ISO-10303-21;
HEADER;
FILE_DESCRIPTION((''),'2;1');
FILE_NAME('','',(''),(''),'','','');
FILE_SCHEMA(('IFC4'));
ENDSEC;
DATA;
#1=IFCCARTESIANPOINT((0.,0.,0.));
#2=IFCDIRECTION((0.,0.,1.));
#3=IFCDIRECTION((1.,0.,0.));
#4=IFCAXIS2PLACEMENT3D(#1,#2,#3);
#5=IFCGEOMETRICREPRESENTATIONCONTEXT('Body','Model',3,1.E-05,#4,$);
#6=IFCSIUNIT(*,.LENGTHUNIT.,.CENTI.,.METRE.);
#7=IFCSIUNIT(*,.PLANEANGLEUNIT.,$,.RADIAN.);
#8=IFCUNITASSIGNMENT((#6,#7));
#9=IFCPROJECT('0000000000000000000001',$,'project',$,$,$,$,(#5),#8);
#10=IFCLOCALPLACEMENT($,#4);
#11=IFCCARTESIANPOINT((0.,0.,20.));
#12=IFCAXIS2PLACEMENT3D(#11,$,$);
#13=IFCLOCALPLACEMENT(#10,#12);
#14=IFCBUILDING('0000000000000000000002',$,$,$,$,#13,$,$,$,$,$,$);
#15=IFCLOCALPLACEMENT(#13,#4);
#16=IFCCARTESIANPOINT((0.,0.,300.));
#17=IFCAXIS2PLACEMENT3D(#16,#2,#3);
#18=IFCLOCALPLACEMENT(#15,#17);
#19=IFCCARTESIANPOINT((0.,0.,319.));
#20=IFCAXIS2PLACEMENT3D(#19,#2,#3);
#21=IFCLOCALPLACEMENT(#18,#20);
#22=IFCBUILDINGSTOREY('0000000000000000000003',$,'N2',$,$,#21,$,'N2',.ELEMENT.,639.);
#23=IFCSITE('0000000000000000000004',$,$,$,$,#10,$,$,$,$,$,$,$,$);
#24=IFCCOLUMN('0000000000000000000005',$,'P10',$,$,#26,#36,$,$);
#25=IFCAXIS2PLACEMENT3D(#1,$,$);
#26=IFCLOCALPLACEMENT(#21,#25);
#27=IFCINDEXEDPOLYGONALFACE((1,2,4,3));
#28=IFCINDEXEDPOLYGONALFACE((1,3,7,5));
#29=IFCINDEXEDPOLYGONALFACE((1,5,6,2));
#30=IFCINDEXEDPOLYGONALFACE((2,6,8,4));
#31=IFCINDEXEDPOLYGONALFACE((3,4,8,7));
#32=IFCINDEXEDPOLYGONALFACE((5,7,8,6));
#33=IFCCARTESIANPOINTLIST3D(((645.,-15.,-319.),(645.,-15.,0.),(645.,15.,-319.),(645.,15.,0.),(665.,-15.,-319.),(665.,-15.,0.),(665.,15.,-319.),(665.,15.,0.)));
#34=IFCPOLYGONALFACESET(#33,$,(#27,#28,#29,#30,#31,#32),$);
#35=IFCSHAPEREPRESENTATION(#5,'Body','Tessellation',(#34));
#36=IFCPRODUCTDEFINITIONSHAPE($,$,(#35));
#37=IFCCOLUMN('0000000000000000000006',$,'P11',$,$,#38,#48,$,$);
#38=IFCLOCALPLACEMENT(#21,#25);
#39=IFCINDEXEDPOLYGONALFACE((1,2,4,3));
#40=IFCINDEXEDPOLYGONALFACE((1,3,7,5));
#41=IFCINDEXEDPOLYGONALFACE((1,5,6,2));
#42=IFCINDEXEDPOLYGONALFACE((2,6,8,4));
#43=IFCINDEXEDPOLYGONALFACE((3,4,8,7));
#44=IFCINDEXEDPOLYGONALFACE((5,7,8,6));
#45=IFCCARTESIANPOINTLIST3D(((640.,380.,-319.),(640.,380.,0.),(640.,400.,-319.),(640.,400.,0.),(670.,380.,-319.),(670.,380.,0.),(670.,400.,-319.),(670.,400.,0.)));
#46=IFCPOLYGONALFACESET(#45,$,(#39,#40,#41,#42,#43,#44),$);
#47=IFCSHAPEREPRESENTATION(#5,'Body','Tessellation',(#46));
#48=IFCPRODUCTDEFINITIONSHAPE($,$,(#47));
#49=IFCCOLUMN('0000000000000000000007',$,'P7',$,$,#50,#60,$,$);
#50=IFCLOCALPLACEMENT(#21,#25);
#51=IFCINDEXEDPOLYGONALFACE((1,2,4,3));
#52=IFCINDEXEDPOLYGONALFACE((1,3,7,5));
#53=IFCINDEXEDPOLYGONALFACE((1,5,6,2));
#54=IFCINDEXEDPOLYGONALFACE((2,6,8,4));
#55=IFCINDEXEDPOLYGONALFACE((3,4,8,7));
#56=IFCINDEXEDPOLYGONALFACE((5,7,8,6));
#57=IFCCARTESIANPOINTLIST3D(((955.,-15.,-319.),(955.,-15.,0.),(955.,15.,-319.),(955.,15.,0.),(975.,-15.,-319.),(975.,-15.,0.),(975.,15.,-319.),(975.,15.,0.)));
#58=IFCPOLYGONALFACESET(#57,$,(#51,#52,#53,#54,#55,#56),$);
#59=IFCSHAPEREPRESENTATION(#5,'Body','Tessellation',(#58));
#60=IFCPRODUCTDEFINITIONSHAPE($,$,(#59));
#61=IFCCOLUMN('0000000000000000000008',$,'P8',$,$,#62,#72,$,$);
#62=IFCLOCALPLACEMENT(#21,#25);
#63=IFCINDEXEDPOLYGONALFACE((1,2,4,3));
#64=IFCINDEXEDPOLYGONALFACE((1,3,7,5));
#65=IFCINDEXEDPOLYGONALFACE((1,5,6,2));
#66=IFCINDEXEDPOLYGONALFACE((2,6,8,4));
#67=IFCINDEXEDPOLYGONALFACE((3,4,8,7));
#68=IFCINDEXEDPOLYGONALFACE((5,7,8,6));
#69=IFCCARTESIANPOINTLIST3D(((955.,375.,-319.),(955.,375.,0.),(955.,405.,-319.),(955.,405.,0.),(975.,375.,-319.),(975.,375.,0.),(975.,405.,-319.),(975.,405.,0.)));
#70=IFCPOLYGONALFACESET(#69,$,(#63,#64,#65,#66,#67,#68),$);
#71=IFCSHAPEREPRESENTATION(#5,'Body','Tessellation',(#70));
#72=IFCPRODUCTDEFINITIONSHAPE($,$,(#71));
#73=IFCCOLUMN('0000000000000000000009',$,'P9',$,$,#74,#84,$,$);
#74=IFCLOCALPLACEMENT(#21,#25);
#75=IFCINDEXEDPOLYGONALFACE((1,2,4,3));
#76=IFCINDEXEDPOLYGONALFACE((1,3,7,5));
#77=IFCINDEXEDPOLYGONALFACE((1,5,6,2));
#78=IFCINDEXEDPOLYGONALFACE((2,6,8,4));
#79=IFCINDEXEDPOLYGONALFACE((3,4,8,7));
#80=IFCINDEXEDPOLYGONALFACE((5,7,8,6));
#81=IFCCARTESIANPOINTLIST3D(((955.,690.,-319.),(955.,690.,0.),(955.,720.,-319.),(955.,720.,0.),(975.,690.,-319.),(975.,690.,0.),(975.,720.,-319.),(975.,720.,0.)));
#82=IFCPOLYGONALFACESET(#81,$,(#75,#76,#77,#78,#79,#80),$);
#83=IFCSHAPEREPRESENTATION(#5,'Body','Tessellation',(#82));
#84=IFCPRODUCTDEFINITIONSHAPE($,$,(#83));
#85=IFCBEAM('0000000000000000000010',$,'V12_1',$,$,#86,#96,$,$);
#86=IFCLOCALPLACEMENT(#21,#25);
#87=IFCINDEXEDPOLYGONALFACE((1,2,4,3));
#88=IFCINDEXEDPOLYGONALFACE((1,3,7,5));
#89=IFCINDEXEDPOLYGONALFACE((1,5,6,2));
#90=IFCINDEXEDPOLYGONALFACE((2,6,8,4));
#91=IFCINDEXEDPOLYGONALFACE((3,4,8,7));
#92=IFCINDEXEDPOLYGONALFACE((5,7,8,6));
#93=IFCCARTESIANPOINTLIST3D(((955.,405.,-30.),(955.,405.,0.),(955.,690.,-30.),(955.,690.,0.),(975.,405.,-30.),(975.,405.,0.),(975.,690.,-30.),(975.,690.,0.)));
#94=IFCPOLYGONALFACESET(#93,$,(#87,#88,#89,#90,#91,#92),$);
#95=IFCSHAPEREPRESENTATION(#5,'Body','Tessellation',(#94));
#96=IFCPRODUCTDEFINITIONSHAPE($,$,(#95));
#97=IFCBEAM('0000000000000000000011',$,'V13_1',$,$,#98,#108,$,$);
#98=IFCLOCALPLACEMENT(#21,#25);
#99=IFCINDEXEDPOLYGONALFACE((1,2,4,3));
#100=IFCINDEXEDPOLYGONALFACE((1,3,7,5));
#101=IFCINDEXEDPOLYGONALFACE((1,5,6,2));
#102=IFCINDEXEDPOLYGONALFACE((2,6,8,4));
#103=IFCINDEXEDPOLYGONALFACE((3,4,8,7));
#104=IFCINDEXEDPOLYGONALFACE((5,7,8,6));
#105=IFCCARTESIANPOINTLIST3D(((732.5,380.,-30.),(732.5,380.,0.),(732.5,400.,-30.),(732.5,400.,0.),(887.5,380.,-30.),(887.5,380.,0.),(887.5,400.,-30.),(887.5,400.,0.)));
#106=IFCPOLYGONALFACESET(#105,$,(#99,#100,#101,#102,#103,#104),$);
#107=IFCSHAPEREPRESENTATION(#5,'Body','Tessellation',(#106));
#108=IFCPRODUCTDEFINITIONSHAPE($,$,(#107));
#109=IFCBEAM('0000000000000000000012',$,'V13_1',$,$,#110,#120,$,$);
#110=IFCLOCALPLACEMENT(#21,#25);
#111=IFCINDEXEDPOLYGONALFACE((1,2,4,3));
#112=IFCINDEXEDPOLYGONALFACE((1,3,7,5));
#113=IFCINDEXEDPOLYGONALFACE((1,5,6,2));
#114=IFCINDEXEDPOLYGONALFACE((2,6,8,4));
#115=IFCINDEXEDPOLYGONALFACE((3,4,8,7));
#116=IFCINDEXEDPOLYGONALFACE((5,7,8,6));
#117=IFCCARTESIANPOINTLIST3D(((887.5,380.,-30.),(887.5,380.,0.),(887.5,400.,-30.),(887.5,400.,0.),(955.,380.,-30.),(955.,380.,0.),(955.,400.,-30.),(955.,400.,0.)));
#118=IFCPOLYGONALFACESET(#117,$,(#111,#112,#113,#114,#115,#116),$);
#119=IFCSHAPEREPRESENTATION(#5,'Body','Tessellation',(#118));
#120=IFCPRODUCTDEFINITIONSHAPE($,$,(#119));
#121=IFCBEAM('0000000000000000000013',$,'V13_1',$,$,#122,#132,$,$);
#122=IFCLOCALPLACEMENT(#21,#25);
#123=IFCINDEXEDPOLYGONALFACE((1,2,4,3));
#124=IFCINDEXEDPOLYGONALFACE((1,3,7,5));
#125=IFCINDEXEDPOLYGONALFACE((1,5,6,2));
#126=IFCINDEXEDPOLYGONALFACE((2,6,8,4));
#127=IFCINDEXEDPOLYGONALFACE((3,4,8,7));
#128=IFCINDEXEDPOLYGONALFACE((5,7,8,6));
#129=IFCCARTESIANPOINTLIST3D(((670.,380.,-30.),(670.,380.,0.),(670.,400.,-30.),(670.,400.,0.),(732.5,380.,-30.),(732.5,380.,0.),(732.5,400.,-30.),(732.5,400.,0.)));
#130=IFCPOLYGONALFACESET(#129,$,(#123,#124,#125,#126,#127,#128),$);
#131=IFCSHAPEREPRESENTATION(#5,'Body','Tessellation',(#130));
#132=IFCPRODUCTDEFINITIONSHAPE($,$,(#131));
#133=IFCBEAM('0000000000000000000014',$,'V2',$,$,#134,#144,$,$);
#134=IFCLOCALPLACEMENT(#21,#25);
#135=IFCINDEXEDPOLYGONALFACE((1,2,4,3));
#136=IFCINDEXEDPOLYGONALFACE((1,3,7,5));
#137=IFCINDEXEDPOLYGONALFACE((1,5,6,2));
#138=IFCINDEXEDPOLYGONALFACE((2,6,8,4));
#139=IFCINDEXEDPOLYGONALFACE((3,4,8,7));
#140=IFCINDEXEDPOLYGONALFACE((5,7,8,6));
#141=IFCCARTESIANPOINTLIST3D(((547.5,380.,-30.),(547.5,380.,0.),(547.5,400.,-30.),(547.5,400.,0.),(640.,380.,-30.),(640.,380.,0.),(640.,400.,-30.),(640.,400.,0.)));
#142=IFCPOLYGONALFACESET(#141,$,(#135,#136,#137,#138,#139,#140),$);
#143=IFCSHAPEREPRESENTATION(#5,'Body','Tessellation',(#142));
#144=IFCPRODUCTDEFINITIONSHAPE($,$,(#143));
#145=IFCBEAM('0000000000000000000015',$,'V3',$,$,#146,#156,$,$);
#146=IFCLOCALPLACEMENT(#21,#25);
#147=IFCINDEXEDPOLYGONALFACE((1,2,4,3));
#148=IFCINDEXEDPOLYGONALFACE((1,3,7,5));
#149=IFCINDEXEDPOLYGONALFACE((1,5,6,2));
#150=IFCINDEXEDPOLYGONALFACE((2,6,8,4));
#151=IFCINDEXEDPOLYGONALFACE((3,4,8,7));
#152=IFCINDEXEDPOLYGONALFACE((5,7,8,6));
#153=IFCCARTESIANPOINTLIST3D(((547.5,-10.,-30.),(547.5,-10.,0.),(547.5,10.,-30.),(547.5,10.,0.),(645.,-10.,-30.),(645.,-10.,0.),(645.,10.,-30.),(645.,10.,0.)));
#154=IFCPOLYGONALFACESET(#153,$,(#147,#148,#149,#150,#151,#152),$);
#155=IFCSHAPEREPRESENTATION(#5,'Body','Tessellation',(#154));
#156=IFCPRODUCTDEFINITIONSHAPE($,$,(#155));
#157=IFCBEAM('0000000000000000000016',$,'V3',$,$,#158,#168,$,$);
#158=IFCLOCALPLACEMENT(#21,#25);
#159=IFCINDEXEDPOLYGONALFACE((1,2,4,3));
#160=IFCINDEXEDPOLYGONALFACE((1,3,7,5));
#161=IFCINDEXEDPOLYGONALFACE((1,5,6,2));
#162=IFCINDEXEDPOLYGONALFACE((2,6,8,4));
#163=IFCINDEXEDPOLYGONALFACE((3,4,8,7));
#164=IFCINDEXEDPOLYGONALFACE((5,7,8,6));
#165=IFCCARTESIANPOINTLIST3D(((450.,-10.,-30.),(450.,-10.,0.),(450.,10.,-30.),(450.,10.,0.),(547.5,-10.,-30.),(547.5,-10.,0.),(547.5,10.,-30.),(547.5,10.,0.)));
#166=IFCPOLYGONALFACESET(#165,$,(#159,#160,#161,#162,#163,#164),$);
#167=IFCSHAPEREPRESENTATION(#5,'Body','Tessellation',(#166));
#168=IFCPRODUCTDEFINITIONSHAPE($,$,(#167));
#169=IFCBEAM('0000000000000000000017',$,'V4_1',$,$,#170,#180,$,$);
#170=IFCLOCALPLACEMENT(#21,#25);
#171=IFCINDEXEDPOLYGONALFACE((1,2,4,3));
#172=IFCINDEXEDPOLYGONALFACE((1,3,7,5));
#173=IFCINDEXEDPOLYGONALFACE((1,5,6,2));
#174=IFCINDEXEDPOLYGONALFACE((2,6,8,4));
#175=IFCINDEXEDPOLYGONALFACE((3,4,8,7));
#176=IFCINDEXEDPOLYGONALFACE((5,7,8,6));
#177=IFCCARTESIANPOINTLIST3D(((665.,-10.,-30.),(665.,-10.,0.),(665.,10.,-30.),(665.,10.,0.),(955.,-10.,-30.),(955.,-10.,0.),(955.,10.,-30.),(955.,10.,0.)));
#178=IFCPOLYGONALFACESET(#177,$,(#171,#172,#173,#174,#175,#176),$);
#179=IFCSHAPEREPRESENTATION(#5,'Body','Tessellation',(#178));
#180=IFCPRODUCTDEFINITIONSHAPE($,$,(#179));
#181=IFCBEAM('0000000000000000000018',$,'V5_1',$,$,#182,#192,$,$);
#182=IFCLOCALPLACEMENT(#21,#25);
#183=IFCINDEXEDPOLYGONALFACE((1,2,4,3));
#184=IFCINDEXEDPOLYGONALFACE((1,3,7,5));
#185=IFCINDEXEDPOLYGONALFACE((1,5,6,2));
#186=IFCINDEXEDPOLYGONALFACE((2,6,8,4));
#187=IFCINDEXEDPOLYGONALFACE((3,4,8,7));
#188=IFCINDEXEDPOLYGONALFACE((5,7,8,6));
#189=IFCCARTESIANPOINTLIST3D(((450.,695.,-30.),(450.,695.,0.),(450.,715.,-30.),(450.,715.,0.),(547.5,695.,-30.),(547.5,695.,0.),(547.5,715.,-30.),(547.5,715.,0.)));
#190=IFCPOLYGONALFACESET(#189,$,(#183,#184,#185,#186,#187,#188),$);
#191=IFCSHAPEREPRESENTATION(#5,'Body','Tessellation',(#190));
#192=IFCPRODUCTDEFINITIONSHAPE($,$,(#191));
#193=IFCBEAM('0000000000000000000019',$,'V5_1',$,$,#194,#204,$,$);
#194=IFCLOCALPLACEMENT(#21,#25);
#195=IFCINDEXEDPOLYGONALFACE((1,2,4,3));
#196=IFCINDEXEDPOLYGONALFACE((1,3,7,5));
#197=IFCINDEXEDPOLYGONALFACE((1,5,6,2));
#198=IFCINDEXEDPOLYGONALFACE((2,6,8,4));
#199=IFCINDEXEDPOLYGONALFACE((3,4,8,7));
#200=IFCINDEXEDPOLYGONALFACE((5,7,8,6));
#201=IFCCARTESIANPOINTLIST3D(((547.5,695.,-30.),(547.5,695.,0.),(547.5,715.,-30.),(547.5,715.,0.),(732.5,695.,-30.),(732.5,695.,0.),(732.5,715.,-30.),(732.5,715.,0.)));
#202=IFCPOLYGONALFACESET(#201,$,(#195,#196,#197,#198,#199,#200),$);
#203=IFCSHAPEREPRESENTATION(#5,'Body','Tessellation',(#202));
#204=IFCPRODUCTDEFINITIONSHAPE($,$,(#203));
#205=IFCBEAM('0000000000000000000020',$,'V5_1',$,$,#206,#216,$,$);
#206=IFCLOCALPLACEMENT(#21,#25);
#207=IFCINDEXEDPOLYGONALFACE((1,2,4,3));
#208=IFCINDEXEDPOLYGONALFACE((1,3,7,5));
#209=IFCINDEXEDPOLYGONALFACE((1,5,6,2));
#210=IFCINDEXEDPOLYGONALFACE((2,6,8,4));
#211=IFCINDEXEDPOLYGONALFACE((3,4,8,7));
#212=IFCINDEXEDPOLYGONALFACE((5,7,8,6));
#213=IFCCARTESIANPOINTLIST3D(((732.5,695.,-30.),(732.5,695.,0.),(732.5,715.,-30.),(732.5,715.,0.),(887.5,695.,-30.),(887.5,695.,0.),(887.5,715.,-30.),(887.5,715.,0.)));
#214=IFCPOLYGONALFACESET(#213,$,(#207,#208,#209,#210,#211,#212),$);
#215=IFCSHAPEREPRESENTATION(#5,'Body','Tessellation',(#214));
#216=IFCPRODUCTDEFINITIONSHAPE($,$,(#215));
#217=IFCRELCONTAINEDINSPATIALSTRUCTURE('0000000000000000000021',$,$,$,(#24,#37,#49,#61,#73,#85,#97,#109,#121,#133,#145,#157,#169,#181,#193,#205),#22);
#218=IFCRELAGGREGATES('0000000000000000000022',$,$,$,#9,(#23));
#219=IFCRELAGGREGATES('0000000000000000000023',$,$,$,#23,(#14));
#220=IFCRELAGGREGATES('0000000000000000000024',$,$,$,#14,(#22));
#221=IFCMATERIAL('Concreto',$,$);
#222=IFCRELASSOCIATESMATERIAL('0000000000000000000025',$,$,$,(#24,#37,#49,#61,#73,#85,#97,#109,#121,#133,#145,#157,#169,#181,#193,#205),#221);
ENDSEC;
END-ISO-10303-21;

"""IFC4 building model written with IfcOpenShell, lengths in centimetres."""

from ifc_helpers import new_model, si_unit, frame, origin_with_axes, origin_2d_with_axis, place, context, project, spatial, rectangle, extrude, material, element, save


model = new_model("IFC4")

# Units and contexts
model_context = context("Model", 3, precision=1e-05, world=origin_with_axes(), identifier="Body")
ifc_project = project(units=[si_unit("LENGTHUNIT", "METRE", prefix="CENTI"), si_unit("PLANEANGLEUNIT", "RADIAN")], contexts=[model_context])

# Site, building, storey
site_placement = place(None, origin_with_axes())
site = spatial("IfcSite", under=ifc_project, at=site_placement)
building_placement = place(site_placement, frame((0.0, 0.0, 20.0)))
building = spatial("IfcBuilding", under=site, at=building_placement)
placement_1 = place(building_placement, origin_with_axes())
placement_2 = place(placement_1, frame((0.0, 0.0, 300.0), z_axis=(0.0, 0.0, 1.0), x_axis=(1.0, 0.0, 0.0)))
storey_placement = place(placement_2, frame((0.0, 0.0, 319.0), z_axis=(0.0, 0.0, 1.0), x_axis=(1.0, 0.0, 0.0)))
storey = spatial("IfcBuildingStorey", under=building, at=storey_placement, Name="N2", LongName="N2", CompositionType="ELEMENT", Elevation=639.0)

# Columns
ifc_material = material(Name="Concreto")
column_1_placement = place(storey_placement, frame((655.0, 0.0, 0.0), z_axis=(0.0, 0.0, 1.0), x_axis=(1.0, 0.0, 0.0)))
element("IfcColumn", 1, at=column_1_placement, inside=storey, material=ifc_material, Name="P10", context=model_context, shape_type="SolidModel", body=[
    extrude(rectangle(XDim=20.0, YDim=30.0, at=origin_2d_with_axis()), origin_with_axes(), (0.0, 0.0, -1.0), 319.0),
])
column_2_placement = place(storey_placement, frame((655.0, 390.0, 0.0), z_axis=(0.0, 0.0, 1.0), x_axis=(1.0, 0.0, 0.0)))
element("IfcColumn", 2, at=column_2_placement, inside=storey, material=ifc_material, Name="P11", context=model_context, shape_type="SolidModel", body=[
    extrude(rectangle(XDim=20.0, YDim=30.0, at=origin_2d_with_axis()), frame((0.0, 0.0, 0.0), z_axis=(0.0, 0.0, 1.0), x_axis=(0.0, 1.0, 0.0)), (0.0, 0.0, -1.0), 319.0),
])
for number, where, z_axis, x_axis, name in (
    (3, (965.0, 0.0, 0.0), (0.0, 0.0, 1.0), (1.0, 0.0, 0.0), "P7"),
    (4, (965.0, 390.0, 0.0), (0.0, 0.0, 1.0), (1.0, 0.0, 0.0), "P8"),
    (5, (965.0, 705.0, 0.0), (0.0, 0.0, 1.0), (1.0, 0.0, 0.0), "P9"),
):
    element("IfcColumn", number, at=place(storey_placement, frame(where, z_axis=z_axis, x_axis=x_axis)), inside=storey, material=ifc_material, Name=name, context=model_context, shape_type="SolidModel", body=[
        extrude(rectangle(XDim=20.0, YDim=30.0, at=origin_2d_with_axis()), origin_with_axes(), (0.0, 0.0, -1.0), 319.0),
    ])

# Beams
beam_1_placement = place(storey_placement, frame((965.0, 547.5, 0.0), z_axis=(0.0, 0.0, 1.0), x_axis=(1.0, 0.0, 0.0)))
element("IfcBeam", 6, at=beam_1_placement, inside=storey, material=ifc_material, Name="V12_1", context=model_context, shape_type="SolidModel", body=[
    extrude(rectangle(XDim=20.0, YDim=30.0, at=origin_2d_with_axis()), frame((0.0, -142.5, -15.0), z_axis=(0.0, 1.0, 0.0), x_axis=(1.0, 0.0, 0.0)), (0.0, 0.0, 1.0), 285.0),
])
beam_2_placement = place(storey_placement, frame((810.0, 390.0, 0.0), z_axis=(0.0, 0.0, 1.0), x_axis=(1.0, 0.0, 0.0)))
element("IfcBeam", 7, at=beam_2_placement, inside=storey, material=ifc_material, Name="V13_1", context=model_context, shape_type="SolidModel", body=[
    extrude(rectangle(XDim=20.0, YDim=30.0, at=origin_2d_with_axis()), frame((-77.5, 0.0, -15.0), z_axis=(1.0, 0.0, 0.0), x_axis=(0.0, 1.0, 0.0)), (0.0, 0.0, 1.0), 155.0),
])
beam_3_placement = place(storey_placement, frame((921.25, 390.0, 0.0), z_axis=(0.0, 0.0, 1.0), x_axis=(1.0, 0.0, 0.0)))
element("IfcBeam", 8, at=beam_3_placement, inside=storey, material=ifc_material, Name="V13_1", context=model_context, shape_type="SolidModel", body=[
    extrude(rectangle(XDim=20.0, YDim=30.0, at=origin_2d_with_axis()), frame((-33.75, 0.0, -15.0), z_axis=(1.0, 0.0, 0.0), x_axis=(0.0, 1.0, 0.0)), (0.0, 0.0, 1.0), 67.5),
])
beam_4_placement = place(storey_placement, frame((701.25, 390.0, 0.0), z_axis=(0.0, 0.0, 1.0), x_axis=(1.0, 0.0, 0.0)))
element("IfcBeam", 9, at=beam_4_placement, inside=storey, material=ifc_material, Name="V13_1", context=model_context, shape_type="SolidModel", body=[
    extrude(rectangle(XDim=20.0, YDim=30.0, at=origin_2d_with_axis()), frame((-31.25, 0.0, -15.0), z_axis=(1.0, 0.0, 0.0), x_axis=(0.0, 1.0, 0.0)), (0.0, 0.0, 1.0), 62.5),
])
beam_5_placement = place(storey_placement, frame((593.75, 390.0, 0.0), z_axis=(0.0, 0.0, 1.0), x_axis=(1.0, 0.0, 0.0)))
element("IfcBeam", 10, at=beam_5_placement, inside=storey, material=ifc_material, Name="V2", context=model_context, shape_type="SolidModel", body=[
    extrude(rectangle(XDim=20.0, YDim=30.0, at=origin_2d_with_axis()), frame((-46.25, 0.0, -15.0), z_axis=(1.0, 0.0, 0.0), x_axis=(0.0, 1.0, 0.0)), (0.0, 0.0, 1.0), 92.5),
])
for number, where, z_axis, x_axis, name in (
    (11, (596.25, 0.0, 0.0), (0.0, 0.0, 1.0), (1.0, 0.0, 0.0), "V3"),
    (12, (498.75, 0.0, 0.0), (0.0, 0.0, 1.0), (1.0, 0.0, 0.0), "V3"),
):
    element("IfcBeam", number, at=place(storey_placement, frame(where, z_axis=z_axis, x_axis=x_axis)), inside=storey, material=ifc_material, Name=name, context=model_context, shape_type="SolidModel", body=[
        extrude(rectangle(XDim=20.0, YDim=30.0, at=origin_2d_with_axis()), frame((-48.75, 0.0, -15.0), z_axis=(1.0, 0.0, 0.0), x_axis=(0.0, 1.0, 0.0)), (0.0, 0.0, 1.0), 97.5),
    ])
beam_6_placement = place(storey_placement, frame((810.0, 0.0, 0.0), z_axis=(0.0, 0.0, 1.0), x_axis=(1.0, 0.0, 0.0)))
element("IfcBeam", 13, at=beam_6_placement, inside=storey, material=ifc_material, Name="V4_1", context=model_context, shape_type="SolidModel", body=[
    extrude(rectangle(XDim=20.0, YDim=30.0, at=origin_2d_with_axis()), frame((-145.0, 0.0, -15.0), z_axis=(1.0, 0.0, 0.0), x_axis=(0.0, 1.0, 0.0)), (0.0, 0.0, 1.0), 290.0),
])
beam_7_placement = place(storey_placement, frame((498.75, 705.0, 0.0), z_axis=(0.0, 0.0, 1.0), x_axis=(1.0, 0.0, 0.0)))
element("IfcBeam", 14, at=beam_7_placement, inside=storey, material=ifc_material, Name="V5_1", context=model_context, shape_type="SolidModel", body=[
    extrude(rectangle(XDim=20.0, YDim=30.0, at=origin_2d_with_axis()), frame((-48.75, 0.0, -15.0), z_axis=(1.0, 0.0, 0.0), x_axis=(0.0, 1.0, 0.0)), (0.0, 0.0, 1.0), 97.5),
])
beam_8_placement = place(storey_placement, frame((640.0, 705.0, 0.0), z_axis=(0.0, 0.0, 1.0), x_axis=(1.0, 0.0, 0.0)))
element("IfcBeam", 15, at=beam_8_placement, inside=storey, material=ifc_material, Name="V5_1", context=model_context, shape_type="SolidModel", body=[
    extrude(rectangle(XDim=20.0, YDim=30.0, at=origin_2d_with_axis()), frame((-92.5, 0.0, -15.0), z_axis=(1.0, 0.0, 0.0), x_axis=(0.0, 1.0, 0.0)), (0.0, 0.0, 1.0), 185.0),
])
beam_9_placement = place(storey_placement, frame((810.0, 705.0, 0.0), z_axis=(0.0, 0.0, 1.0), x_axis=(1.0, 0.0, 0.0)))
element("IfcBeam", 16, at=beam_9_placement, inside=storey, material=ifc_material, Name="V5_1", context=model_context, shape_type="SolidModel", body=[
    extrude(rectangle(XDim=20.0, YDim=30.0, at=origin_2d_with_axis()), frame((-77.5, 0.0, -15.0), z_axis=(1.0, 0.0, 0.0), x_axis=(0.0, 1.0, 0.0)), (0.0, 0.0, 1.0), 155.0),
])

save(model, "model.ifc")
